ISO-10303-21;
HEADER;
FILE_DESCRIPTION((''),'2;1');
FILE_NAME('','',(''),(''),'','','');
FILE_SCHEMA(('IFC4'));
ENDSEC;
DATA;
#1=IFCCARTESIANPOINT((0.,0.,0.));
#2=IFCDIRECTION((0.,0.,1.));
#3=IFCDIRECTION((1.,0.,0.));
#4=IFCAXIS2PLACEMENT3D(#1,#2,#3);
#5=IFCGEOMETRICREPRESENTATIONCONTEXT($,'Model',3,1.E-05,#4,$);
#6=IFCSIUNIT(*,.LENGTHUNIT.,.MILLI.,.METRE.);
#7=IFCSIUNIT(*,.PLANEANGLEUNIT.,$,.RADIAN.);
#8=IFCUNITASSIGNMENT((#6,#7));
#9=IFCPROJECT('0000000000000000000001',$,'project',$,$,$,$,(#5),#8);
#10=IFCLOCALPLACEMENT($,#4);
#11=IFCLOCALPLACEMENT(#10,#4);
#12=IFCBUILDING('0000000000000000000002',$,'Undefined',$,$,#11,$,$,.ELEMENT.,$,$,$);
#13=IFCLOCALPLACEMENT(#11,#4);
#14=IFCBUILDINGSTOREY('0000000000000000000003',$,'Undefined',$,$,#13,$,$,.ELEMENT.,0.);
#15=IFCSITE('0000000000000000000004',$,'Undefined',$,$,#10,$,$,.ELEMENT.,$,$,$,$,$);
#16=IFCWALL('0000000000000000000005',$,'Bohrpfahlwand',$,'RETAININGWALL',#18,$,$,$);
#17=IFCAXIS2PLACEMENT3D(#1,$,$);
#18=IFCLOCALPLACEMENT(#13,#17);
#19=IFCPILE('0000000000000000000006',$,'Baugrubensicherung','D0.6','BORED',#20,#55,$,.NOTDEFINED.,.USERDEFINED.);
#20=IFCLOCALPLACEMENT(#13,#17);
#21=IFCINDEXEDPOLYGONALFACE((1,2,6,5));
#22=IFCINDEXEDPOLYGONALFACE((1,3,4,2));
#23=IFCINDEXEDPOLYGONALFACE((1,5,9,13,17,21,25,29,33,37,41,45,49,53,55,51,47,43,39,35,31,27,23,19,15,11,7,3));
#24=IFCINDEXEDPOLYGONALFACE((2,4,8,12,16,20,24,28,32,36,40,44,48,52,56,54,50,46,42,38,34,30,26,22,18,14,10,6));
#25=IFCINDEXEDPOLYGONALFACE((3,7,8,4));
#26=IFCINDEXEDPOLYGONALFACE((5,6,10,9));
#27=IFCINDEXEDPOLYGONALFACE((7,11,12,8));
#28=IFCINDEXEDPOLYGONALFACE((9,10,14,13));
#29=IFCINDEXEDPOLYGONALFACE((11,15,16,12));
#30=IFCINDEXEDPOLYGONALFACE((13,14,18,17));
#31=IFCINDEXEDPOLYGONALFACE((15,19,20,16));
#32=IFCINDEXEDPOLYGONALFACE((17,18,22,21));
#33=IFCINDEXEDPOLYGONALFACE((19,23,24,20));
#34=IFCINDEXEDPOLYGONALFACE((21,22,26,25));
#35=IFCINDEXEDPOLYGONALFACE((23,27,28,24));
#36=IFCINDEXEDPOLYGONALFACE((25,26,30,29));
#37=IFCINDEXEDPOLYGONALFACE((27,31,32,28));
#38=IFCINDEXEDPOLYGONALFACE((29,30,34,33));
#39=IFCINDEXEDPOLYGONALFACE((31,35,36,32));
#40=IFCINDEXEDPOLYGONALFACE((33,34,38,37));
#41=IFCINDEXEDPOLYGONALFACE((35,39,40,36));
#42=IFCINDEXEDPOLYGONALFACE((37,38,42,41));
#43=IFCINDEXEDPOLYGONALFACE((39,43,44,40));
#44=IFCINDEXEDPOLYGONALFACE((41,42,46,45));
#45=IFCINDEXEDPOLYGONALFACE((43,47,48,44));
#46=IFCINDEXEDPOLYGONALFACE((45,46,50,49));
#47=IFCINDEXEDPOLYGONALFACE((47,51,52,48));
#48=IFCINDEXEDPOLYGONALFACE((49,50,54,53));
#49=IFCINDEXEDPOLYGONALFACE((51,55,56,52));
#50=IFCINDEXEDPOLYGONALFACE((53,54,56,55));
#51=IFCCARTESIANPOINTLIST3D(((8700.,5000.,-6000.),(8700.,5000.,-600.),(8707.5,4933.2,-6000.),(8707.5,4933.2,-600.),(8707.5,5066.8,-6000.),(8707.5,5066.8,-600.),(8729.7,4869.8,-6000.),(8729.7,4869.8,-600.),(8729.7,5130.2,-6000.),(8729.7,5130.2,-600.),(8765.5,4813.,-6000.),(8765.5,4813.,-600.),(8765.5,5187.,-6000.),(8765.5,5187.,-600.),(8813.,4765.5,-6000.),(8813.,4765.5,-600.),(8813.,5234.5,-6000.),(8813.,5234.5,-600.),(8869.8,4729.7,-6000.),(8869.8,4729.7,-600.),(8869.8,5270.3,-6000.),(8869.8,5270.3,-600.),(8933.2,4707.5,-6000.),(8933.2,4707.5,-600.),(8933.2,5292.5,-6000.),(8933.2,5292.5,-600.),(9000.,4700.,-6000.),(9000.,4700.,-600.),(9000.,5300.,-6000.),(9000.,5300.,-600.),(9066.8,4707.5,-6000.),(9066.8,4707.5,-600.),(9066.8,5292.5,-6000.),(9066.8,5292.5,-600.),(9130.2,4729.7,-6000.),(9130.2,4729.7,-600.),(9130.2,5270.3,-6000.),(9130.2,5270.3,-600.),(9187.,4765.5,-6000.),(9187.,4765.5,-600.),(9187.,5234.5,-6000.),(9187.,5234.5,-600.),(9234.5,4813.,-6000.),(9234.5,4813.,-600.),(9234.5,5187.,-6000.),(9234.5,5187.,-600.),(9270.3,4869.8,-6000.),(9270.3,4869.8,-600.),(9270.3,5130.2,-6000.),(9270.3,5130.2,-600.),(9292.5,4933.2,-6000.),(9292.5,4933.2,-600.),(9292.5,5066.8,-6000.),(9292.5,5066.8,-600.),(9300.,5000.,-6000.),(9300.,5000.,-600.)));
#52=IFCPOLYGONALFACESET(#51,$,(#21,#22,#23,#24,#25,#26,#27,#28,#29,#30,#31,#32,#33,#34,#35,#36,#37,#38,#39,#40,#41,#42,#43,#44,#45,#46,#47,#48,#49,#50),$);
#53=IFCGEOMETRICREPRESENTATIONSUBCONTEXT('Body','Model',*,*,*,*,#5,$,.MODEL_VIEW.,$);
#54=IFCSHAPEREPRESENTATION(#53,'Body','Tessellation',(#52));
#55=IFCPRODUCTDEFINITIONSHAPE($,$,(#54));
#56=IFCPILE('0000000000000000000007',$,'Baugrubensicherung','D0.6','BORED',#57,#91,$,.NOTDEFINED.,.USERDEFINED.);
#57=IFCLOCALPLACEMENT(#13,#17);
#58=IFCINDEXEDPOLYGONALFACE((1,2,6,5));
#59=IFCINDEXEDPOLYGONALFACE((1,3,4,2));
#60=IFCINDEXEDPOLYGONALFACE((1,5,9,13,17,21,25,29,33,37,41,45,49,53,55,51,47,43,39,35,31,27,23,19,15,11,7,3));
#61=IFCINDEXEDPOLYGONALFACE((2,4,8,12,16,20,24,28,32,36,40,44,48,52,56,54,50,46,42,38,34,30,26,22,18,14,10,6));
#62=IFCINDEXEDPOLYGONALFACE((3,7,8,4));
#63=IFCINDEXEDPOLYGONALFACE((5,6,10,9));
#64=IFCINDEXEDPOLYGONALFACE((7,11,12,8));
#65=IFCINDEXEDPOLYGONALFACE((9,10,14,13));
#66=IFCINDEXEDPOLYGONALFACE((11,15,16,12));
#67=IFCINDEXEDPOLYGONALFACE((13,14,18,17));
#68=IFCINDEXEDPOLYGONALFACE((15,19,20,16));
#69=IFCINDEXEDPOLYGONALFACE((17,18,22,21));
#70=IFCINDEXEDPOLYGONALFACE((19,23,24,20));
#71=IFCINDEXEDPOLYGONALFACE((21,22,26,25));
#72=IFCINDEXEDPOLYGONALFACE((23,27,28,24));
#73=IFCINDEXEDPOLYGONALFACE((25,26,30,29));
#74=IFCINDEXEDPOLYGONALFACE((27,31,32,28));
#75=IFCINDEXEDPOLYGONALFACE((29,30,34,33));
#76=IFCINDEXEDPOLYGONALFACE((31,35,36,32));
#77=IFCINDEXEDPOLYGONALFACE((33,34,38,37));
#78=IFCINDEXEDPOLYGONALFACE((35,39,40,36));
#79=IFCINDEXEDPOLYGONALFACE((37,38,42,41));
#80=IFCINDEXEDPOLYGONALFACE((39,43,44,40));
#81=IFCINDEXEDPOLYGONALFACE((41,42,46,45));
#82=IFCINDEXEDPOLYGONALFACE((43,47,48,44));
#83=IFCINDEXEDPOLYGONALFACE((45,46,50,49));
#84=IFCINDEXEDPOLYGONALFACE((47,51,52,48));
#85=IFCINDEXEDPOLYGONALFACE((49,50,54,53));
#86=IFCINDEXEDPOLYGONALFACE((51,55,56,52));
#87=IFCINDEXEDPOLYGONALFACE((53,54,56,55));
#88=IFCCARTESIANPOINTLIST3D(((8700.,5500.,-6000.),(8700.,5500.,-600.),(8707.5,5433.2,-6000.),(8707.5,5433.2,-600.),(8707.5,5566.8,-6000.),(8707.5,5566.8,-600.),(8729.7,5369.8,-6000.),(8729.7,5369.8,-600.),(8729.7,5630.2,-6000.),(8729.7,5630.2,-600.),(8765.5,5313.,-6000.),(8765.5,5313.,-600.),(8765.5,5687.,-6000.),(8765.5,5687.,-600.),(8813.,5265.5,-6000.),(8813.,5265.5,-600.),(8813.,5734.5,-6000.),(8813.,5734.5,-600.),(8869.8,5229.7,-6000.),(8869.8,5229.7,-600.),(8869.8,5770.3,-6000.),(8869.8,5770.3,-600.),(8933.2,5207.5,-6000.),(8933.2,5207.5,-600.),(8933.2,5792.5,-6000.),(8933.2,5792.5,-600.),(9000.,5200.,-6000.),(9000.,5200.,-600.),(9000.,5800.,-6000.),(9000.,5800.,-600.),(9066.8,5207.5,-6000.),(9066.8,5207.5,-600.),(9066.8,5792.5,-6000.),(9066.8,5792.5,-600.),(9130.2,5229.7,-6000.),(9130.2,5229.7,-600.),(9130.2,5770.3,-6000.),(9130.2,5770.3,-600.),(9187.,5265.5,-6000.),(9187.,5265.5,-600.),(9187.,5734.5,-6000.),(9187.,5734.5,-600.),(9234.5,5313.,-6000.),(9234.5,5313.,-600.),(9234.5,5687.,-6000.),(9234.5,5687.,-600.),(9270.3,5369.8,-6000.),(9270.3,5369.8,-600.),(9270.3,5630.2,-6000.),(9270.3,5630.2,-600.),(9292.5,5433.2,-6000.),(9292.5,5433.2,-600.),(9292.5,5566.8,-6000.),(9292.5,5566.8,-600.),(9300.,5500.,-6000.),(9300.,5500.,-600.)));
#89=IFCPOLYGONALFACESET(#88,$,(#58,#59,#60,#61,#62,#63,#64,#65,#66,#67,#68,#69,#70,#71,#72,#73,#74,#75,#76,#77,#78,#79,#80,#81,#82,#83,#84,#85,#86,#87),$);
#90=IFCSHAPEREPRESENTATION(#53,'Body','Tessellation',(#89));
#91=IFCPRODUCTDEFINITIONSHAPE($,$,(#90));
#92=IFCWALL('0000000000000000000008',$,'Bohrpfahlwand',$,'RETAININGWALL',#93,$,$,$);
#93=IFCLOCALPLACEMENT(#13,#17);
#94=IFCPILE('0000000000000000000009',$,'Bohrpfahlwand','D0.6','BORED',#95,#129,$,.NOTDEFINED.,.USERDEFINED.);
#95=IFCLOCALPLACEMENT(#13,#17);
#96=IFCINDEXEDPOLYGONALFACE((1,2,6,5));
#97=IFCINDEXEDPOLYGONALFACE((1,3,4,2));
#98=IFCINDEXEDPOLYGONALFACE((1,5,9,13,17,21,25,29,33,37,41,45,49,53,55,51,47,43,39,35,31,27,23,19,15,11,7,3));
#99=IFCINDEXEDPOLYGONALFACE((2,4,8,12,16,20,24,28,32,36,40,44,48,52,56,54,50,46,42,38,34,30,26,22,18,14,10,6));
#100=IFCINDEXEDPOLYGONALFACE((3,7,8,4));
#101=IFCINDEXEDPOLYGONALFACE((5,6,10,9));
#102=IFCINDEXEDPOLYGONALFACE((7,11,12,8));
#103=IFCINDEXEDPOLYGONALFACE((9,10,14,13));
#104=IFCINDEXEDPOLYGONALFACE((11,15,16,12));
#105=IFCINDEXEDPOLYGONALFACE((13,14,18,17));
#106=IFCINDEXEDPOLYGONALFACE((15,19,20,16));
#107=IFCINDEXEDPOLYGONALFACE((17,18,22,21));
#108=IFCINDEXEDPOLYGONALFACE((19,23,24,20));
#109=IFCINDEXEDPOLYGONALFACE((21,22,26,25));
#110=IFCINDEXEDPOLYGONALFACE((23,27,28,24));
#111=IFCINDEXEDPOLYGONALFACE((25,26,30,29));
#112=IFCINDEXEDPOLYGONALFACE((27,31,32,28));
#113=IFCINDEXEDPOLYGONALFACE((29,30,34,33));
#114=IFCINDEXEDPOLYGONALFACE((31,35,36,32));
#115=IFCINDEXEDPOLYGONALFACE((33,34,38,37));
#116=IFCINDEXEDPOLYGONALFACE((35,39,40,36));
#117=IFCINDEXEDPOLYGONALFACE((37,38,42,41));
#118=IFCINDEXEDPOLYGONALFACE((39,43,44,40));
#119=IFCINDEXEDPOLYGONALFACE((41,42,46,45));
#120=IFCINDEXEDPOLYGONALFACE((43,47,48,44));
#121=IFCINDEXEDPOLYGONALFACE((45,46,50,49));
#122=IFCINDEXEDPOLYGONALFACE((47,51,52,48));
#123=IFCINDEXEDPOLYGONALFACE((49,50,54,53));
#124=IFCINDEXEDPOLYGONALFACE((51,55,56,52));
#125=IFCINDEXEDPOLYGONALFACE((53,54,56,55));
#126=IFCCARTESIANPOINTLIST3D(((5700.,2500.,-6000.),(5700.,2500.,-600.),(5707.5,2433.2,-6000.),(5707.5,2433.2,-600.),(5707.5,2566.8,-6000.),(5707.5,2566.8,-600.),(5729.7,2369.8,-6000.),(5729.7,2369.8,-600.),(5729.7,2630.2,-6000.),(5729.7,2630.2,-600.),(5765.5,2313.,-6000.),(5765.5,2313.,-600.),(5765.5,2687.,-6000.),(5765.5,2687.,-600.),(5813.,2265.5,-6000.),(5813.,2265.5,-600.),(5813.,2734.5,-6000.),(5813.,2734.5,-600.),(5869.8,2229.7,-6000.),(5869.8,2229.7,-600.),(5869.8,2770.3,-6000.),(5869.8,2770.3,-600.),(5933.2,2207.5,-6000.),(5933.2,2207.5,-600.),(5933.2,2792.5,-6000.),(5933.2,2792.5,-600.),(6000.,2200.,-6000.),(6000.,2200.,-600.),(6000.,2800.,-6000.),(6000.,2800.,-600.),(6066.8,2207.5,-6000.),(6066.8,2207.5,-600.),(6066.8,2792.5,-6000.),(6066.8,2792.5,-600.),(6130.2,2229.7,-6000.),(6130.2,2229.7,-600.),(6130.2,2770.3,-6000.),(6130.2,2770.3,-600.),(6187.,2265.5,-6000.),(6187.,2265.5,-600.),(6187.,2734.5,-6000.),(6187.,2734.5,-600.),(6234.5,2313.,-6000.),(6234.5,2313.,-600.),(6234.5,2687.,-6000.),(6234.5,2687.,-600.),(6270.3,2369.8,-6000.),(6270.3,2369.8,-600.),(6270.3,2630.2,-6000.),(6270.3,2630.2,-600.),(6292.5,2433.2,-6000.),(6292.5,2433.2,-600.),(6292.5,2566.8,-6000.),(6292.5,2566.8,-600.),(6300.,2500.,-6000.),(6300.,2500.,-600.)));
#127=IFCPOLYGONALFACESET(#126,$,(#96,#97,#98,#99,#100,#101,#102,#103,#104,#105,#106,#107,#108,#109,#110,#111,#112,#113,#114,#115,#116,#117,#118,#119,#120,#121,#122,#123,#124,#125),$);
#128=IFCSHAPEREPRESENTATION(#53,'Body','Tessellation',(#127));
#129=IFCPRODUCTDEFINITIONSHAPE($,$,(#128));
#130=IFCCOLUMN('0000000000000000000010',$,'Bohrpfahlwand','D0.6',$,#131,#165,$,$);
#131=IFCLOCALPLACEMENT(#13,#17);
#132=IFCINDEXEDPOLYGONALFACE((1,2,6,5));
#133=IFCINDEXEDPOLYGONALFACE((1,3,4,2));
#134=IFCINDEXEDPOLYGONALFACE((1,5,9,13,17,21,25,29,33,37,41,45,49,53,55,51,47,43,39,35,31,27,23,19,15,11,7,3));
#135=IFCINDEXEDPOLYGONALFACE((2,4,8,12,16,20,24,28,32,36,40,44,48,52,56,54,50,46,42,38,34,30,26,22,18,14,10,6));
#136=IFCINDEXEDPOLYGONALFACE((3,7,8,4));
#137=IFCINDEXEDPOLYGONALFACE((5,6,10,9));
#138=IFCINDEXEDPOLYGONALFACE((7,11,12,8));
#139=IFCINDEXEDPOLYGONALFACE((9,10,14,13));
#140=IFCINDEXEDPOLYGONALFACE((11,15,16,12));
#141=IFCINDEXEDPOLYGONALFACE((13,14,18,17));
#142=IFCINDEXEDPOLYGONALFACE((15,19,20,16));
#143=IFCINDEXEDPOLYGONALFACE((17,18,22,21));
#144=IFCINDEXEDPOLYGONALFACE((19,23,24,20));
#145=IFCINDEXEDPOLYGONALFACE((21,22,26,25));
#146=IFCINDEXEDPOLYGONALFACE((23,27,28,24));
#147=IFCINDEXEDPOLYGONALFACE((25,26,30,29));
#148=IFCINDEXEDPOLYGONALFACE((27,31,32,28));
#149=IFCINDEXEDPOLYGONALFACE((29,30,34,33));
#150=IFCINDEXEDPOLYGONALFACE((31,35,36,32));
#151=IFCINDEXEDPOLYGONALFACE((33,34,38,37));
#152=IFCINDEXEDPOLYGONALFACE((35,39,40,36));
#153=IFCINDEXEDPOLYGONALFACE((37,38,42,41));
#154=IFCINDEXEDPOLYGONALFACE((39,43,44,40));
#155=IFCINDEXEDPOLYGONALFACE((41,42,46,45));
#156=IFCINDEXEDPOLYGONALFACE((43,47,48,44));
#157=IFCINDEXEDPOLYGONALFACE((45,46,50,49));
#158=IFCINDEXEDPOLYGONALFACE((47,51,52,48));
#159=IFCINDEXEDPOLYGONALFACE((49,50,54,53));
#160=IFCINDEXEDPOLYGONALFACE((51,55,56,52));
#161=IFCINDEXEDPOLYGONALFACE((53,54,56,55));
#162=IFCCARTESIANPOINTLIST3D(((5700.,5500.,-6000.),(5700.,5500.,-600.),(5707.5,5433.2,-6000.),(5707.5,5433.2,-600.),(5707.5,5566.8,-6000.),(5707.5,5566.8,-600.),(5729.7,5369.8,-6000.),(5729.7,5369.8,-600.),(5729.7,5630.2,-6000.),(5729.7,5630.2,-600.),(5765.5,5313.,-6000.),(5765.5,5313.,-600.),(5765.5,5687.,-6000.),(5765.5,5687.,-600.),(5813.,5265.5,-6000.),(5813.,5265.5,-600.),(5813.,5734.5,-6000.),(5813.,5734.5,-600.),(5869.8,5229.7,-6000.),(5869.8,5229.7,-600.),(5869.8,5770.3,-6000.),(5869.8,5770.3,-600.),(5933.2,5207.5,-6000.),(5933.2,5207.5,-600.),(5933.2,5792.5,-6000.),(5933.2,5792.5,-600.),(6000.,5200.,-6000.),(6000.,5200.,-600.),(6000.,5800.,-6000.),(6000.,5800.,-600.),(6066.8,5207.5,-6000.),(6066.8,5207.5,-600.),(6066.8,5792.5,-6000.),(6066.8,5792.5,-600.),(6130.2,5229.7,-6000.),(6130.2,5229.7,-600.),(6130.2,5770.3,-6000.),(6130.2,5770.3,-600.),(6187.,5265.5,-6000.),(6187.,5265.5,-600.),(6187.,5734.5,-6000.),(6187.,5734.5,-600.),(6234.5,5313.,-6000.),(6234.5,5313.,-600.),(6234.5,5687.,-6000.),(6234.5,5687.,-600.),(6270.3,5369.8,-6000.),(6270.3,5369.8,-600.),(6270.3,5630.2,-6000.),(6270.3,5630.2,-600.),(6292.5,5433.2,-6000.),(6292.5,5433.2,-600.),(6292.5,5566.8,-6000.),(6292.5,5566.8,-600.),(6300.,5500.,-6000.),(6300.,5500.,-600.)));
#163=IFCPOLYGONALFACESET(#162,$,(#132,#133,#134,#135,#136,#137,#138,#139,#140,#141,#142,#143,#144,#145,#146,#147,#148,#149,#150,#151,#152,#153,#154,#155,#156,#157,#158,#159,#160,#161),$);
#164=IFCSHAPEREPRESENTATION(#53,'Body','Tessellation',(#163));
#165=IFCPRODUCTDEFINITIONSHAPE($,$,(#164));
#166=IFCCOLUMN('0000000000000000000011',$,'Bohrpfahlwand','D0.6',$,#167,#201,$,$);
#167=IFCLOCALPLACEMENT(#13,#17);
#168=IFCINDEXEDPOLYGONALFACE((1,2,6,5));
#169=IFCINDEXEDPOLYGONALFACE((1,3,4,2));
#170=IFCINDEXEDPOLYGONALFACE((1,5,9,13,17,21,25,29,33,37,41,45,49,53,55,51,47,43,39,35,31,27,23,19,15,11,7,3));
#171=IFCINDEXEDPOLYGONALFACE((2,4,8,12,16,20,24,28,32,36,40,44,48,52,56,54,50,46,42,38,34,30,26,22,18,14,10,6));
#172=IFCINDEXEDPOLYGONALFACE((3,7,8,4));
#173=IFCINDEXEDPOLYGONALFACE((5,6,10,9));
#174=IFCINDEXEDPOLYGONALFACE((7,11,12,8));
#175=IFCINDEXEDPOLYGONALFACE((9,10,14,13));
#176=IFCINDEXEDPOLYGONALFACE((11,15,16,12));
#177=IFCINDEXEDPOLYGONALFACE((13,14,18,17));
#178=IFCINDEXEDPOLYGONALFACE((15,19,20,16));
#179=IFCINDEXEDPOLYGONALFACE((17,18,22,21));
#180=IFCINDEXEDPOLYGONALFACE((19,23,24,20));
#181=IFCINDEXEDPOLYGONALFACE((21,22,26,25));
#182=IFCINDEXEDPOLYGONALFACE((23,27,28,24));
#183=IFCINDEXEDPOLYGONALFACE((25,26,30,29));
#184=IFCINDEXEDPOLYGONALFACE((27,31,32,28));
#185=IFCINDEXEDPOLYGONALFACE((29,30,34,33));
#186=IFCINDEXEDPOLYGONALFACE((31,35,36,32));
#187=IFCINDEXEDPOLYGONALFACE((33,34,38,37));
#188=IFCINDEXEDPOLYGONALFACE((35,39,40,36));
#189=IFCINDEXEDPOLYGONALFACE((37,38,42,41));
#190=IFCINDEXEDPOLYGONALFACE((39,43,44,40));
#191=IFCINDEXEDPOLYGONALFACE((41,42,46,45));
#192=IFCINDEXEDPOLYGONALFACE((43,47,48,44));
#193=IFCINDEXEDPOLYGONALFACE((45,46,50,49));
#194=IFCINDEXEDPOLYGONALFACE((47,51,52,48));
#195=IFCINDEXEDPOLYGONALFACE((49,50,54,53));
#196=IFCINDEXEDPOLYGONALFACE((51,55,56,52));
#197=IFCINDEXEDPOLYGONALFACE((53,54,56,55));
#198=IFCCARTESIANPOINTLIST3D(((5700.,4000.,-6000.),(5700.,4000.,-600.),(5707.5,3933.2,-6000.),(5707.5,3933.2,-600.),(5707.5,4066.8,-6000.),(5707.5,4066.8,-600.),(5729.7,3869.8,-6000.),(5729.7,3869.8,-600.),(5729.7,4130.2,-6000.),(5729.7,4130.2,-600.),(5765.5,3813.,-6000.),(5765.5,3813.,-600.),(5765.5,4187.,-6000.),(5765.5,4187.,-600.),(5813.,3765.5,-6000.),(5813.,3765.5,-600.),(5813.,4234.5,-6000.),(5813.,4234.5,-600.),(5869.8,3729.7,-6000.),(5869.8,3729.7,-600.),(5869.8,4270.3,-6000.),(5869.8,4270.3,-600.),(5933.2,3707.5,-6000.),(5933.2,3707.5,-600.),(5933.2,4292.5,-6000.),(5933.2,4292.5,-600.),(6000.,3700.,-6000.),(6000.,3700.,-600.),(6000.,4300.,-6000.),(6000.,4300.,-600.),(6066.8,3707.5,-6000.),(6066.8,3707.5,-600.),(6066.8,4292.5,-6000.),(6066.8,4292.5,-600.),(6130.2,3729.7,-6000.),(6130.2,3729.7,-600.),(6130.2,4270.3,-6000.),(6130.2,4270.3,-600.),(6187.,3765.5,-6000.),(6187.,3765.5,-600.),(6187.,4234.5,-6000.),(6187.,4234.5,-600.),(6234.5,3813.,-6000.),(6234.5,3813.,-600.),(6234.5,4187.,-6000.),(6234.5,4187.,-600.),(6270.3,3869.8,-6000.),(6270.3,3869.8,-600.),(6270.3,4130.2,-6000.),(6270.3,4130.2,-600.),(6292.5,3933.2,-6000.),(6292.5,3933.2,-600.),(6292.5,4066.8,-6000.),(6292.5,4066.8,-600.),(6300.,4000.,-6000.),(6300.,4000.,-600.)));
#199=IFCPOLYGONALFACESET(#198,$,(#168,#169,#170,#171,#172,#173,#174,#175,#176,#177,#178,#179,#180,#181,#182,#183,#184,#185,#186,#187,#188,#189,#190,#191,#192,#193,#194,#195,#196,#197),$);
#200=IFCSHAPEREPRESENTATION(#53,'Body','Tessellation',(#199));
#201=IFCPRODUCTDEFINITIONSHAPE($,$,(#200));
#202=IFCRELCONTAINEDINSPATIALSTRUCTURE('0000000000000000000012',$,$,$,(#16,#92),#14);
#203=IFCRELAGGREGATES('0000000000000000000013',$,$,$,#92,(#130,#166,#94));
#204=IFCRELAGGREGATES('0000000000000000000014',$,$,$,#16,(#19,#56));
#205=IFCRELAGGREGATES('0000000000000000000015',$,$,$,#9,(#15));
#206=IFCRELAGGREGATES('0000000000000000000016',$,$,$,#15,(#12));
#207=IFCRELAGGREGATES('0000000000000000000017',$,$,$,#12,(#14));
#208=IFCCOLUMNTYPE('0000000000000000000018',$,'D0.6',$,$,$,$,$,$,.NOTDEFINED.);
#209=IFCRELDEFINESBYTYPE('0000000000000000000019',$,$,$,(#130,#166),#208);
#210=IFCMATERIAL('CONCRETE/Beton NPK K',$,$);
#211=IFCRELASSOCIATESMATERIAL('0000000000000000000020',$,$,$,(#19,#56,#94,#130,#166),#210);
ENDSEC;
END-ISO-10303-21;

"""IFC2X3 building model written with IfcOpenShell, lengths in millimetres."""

from ifc_helpers import new_model, si_unit, frame, origin_with_axes, origin_2d_with_axis, place, context, subcontext, project, spatial, circle, extrude, material, type_object, element, aggregate, save


model = new_model("IFC2X3")

# Units and contexts
model_context = context("Model", 3, precision=1e-05, world=origin_with_axes())
body_context = subcontext(model_context, "Body", "Model", "MODEL_VIEW")
ifc_project = project(units=[si_unit("LENGTHUNIT", "METRE", prefix="MILLI"), si_unit("PLANEANGLEUNIT", "RADIAN")], contexts=[model_context])

# Site, building, storey
site_placement = place(None, origin_with_axes())
site = spatial("IfcSite", under=ifc_project, at=site_placement, Name="Undefined", CompositionType="ELEMENT")
building_placement = place(site_placement, origin_with_axes())
building = spatial("IfcBuilding", under=site, at=building_placement, Name="Undefined", CompositionType="ELEMENT")
storey_placement = place(building_placement, origin_with_axes())
storey = spatial("IfcBuildingStorey", under=building, at=storey_placement, Name="Undefined", CompositionType="ELEMENT", Elevation=0.0)

# Wall, piles
wall_1_placement = place(storey_placement, origin_with_axes())
wall_1 = element("IfcWall", 1, at=wall_1_placement, inside=storey, Name="Bohrpfahlwand", ObjectType="RETAININGWALL")
ifc_material_1 = material(Name="CONCRETE/Beton NPK K")
pile_1_placement = place(wall_1_placement, frame((9000.0, 5000.0, -6000.0), z_axis=(0.0, 1.0, 0.0), x_axis=(0.0, 0.0, 1.0)))
pile_1 = element("IfcPile", 2, at=pile_1_placement, material=ifc_material_1, Name="Baugrubensicherung", Description="D0.6", ObjectType="BORED", ConstructionType="USERDEFINED", PredefinedType="NOTDEFINED", context=body_context, shape_type="SweptSolid", body=[
    extrude(circle(Radius=300.0, at=origin_2d_with_axis()), frame((5400.0, 0.0, 0.0), z_axis=(-1.0, 0.0, 0.0), x_axis=(0.0, -1.0, 0.0)), (0.0, 0.0, 1.0), 5400.0),
])
pile_2_placement = place(wall_1_placement, frame((9000.0, 5500.0, -6000.0), z_axis=(0.0, 1.0, 0.0), x_axis=(0.0, 0.0, 1.0)))
pile_2 = element("IfcPile", 3, at=pile_2_placement, material=ifc_material_1, Name="Baugrubensicherung", Description="D0.6", ObjectType="BORED", ConstructionType="USERDEFINED", PredefinedType="NOTDEFINED", context=body_context, shape_type="SweptSolid", body=[
    extrude(circle(Radius=300.0, at=origin_2d_with_axis()), frame((5400.0, 0.0, 0.0), z_axis=(-1.0, 0.0, 0.0), x_axis=(0.0, -1.0, 0.0)), (0.0, 0.0, 1.0), 5400.0),
])

# Wall, pile, columns
wall_2_placement = place(storey_placement, origin_with_axes())
wall_2 = element("IfcWall", 4, at=wall_2_placement, inside=storey, Name="Bohrpfahlwand", ObjectType="RETAININGWALL")
pile_3_placement = place(wall_2_placement, frame((6000.0, 2500.0, -6000.0), z_axis=(0.0, 1.0, 0.0), x_axis=(0.0, 0.0, 1.0)))
pile_3 = element("IfcPile", 5, at=pile_3_placement, material=ifc_material_1, Name="Bohrpfahlwand", Description="D0.6", ObjectType="BORED", ConstructionType="USERDEFINED", PredefinedType="NOTDEFINED", context=body_context, shape_type="SweptSolid", body=[
    extrude(circle(Radius=300.0, at=origin_2d_with_axis()), frame((5400.0, 0.0, 0.0), z_axis=(-1.0, 0.0, 0.0), x_axis=(0.0, -1.0, 0.0)), (0.0, 0.0, 1.0), 5400.0),
])
column_type = type_object("IfcColumnType", Name="D0.6", PredefinedType="NOTDEFINED")
column_1_placement = place(wall_2_placement, frame((6000.0, 5500.0, -6000.0), z_axis=(0.0, 0.0, 1.0), x_axis=(0.0, 1.0, 0.0)))
column_1 = element("IfcColumn", 6, at=column_1_placement, type_object=column_type, material=ifc_material_1, Name="Bohrpfahlwand", Description="D0.6", context=body_context, shape_type="SweptSolid", body=[
    extrude(circle(Radius=300.0, at=origin_2d_with_axis()), frame((0.0, 0.0, 5400.0), z_axis=(0.0, 0.0, -1.0), x_axis=(0.0, 1.0, 0.0)), (0.0, 0.0, 1.0), 5400.0),
])
column_2_placement = place(wall_2_placement, frame((6000.0, 4000.0, -6000.0), z_axis=(0.0, 0.0, 1.0), x_axis=(0.0, 1.0, 0.0)))
column_2 = element("IfcColumn", 7, at=column_2_placement, type_object=column_type, material=ifc_material_1, Name="Bohrpfahlwand", Description="D0.6", context=body_context, shape_type="SweptSolid", body=[
    extrude(circle(Radius=300.0, at=origin_2d_with_axis()), frame((0.0, 0.0, 5400.0), z_axis=(0.0, 0.0, -1.0), x_axis=(0.0, 1.0, 0.0)), (0.0, 0.0, 1.0), 5400.0),
])
aggregate(wall_2, [column_1, column_2, pile_3])

aggregate(wall_1, [pile_1, pile_2])

save(model, "model.ifc")
